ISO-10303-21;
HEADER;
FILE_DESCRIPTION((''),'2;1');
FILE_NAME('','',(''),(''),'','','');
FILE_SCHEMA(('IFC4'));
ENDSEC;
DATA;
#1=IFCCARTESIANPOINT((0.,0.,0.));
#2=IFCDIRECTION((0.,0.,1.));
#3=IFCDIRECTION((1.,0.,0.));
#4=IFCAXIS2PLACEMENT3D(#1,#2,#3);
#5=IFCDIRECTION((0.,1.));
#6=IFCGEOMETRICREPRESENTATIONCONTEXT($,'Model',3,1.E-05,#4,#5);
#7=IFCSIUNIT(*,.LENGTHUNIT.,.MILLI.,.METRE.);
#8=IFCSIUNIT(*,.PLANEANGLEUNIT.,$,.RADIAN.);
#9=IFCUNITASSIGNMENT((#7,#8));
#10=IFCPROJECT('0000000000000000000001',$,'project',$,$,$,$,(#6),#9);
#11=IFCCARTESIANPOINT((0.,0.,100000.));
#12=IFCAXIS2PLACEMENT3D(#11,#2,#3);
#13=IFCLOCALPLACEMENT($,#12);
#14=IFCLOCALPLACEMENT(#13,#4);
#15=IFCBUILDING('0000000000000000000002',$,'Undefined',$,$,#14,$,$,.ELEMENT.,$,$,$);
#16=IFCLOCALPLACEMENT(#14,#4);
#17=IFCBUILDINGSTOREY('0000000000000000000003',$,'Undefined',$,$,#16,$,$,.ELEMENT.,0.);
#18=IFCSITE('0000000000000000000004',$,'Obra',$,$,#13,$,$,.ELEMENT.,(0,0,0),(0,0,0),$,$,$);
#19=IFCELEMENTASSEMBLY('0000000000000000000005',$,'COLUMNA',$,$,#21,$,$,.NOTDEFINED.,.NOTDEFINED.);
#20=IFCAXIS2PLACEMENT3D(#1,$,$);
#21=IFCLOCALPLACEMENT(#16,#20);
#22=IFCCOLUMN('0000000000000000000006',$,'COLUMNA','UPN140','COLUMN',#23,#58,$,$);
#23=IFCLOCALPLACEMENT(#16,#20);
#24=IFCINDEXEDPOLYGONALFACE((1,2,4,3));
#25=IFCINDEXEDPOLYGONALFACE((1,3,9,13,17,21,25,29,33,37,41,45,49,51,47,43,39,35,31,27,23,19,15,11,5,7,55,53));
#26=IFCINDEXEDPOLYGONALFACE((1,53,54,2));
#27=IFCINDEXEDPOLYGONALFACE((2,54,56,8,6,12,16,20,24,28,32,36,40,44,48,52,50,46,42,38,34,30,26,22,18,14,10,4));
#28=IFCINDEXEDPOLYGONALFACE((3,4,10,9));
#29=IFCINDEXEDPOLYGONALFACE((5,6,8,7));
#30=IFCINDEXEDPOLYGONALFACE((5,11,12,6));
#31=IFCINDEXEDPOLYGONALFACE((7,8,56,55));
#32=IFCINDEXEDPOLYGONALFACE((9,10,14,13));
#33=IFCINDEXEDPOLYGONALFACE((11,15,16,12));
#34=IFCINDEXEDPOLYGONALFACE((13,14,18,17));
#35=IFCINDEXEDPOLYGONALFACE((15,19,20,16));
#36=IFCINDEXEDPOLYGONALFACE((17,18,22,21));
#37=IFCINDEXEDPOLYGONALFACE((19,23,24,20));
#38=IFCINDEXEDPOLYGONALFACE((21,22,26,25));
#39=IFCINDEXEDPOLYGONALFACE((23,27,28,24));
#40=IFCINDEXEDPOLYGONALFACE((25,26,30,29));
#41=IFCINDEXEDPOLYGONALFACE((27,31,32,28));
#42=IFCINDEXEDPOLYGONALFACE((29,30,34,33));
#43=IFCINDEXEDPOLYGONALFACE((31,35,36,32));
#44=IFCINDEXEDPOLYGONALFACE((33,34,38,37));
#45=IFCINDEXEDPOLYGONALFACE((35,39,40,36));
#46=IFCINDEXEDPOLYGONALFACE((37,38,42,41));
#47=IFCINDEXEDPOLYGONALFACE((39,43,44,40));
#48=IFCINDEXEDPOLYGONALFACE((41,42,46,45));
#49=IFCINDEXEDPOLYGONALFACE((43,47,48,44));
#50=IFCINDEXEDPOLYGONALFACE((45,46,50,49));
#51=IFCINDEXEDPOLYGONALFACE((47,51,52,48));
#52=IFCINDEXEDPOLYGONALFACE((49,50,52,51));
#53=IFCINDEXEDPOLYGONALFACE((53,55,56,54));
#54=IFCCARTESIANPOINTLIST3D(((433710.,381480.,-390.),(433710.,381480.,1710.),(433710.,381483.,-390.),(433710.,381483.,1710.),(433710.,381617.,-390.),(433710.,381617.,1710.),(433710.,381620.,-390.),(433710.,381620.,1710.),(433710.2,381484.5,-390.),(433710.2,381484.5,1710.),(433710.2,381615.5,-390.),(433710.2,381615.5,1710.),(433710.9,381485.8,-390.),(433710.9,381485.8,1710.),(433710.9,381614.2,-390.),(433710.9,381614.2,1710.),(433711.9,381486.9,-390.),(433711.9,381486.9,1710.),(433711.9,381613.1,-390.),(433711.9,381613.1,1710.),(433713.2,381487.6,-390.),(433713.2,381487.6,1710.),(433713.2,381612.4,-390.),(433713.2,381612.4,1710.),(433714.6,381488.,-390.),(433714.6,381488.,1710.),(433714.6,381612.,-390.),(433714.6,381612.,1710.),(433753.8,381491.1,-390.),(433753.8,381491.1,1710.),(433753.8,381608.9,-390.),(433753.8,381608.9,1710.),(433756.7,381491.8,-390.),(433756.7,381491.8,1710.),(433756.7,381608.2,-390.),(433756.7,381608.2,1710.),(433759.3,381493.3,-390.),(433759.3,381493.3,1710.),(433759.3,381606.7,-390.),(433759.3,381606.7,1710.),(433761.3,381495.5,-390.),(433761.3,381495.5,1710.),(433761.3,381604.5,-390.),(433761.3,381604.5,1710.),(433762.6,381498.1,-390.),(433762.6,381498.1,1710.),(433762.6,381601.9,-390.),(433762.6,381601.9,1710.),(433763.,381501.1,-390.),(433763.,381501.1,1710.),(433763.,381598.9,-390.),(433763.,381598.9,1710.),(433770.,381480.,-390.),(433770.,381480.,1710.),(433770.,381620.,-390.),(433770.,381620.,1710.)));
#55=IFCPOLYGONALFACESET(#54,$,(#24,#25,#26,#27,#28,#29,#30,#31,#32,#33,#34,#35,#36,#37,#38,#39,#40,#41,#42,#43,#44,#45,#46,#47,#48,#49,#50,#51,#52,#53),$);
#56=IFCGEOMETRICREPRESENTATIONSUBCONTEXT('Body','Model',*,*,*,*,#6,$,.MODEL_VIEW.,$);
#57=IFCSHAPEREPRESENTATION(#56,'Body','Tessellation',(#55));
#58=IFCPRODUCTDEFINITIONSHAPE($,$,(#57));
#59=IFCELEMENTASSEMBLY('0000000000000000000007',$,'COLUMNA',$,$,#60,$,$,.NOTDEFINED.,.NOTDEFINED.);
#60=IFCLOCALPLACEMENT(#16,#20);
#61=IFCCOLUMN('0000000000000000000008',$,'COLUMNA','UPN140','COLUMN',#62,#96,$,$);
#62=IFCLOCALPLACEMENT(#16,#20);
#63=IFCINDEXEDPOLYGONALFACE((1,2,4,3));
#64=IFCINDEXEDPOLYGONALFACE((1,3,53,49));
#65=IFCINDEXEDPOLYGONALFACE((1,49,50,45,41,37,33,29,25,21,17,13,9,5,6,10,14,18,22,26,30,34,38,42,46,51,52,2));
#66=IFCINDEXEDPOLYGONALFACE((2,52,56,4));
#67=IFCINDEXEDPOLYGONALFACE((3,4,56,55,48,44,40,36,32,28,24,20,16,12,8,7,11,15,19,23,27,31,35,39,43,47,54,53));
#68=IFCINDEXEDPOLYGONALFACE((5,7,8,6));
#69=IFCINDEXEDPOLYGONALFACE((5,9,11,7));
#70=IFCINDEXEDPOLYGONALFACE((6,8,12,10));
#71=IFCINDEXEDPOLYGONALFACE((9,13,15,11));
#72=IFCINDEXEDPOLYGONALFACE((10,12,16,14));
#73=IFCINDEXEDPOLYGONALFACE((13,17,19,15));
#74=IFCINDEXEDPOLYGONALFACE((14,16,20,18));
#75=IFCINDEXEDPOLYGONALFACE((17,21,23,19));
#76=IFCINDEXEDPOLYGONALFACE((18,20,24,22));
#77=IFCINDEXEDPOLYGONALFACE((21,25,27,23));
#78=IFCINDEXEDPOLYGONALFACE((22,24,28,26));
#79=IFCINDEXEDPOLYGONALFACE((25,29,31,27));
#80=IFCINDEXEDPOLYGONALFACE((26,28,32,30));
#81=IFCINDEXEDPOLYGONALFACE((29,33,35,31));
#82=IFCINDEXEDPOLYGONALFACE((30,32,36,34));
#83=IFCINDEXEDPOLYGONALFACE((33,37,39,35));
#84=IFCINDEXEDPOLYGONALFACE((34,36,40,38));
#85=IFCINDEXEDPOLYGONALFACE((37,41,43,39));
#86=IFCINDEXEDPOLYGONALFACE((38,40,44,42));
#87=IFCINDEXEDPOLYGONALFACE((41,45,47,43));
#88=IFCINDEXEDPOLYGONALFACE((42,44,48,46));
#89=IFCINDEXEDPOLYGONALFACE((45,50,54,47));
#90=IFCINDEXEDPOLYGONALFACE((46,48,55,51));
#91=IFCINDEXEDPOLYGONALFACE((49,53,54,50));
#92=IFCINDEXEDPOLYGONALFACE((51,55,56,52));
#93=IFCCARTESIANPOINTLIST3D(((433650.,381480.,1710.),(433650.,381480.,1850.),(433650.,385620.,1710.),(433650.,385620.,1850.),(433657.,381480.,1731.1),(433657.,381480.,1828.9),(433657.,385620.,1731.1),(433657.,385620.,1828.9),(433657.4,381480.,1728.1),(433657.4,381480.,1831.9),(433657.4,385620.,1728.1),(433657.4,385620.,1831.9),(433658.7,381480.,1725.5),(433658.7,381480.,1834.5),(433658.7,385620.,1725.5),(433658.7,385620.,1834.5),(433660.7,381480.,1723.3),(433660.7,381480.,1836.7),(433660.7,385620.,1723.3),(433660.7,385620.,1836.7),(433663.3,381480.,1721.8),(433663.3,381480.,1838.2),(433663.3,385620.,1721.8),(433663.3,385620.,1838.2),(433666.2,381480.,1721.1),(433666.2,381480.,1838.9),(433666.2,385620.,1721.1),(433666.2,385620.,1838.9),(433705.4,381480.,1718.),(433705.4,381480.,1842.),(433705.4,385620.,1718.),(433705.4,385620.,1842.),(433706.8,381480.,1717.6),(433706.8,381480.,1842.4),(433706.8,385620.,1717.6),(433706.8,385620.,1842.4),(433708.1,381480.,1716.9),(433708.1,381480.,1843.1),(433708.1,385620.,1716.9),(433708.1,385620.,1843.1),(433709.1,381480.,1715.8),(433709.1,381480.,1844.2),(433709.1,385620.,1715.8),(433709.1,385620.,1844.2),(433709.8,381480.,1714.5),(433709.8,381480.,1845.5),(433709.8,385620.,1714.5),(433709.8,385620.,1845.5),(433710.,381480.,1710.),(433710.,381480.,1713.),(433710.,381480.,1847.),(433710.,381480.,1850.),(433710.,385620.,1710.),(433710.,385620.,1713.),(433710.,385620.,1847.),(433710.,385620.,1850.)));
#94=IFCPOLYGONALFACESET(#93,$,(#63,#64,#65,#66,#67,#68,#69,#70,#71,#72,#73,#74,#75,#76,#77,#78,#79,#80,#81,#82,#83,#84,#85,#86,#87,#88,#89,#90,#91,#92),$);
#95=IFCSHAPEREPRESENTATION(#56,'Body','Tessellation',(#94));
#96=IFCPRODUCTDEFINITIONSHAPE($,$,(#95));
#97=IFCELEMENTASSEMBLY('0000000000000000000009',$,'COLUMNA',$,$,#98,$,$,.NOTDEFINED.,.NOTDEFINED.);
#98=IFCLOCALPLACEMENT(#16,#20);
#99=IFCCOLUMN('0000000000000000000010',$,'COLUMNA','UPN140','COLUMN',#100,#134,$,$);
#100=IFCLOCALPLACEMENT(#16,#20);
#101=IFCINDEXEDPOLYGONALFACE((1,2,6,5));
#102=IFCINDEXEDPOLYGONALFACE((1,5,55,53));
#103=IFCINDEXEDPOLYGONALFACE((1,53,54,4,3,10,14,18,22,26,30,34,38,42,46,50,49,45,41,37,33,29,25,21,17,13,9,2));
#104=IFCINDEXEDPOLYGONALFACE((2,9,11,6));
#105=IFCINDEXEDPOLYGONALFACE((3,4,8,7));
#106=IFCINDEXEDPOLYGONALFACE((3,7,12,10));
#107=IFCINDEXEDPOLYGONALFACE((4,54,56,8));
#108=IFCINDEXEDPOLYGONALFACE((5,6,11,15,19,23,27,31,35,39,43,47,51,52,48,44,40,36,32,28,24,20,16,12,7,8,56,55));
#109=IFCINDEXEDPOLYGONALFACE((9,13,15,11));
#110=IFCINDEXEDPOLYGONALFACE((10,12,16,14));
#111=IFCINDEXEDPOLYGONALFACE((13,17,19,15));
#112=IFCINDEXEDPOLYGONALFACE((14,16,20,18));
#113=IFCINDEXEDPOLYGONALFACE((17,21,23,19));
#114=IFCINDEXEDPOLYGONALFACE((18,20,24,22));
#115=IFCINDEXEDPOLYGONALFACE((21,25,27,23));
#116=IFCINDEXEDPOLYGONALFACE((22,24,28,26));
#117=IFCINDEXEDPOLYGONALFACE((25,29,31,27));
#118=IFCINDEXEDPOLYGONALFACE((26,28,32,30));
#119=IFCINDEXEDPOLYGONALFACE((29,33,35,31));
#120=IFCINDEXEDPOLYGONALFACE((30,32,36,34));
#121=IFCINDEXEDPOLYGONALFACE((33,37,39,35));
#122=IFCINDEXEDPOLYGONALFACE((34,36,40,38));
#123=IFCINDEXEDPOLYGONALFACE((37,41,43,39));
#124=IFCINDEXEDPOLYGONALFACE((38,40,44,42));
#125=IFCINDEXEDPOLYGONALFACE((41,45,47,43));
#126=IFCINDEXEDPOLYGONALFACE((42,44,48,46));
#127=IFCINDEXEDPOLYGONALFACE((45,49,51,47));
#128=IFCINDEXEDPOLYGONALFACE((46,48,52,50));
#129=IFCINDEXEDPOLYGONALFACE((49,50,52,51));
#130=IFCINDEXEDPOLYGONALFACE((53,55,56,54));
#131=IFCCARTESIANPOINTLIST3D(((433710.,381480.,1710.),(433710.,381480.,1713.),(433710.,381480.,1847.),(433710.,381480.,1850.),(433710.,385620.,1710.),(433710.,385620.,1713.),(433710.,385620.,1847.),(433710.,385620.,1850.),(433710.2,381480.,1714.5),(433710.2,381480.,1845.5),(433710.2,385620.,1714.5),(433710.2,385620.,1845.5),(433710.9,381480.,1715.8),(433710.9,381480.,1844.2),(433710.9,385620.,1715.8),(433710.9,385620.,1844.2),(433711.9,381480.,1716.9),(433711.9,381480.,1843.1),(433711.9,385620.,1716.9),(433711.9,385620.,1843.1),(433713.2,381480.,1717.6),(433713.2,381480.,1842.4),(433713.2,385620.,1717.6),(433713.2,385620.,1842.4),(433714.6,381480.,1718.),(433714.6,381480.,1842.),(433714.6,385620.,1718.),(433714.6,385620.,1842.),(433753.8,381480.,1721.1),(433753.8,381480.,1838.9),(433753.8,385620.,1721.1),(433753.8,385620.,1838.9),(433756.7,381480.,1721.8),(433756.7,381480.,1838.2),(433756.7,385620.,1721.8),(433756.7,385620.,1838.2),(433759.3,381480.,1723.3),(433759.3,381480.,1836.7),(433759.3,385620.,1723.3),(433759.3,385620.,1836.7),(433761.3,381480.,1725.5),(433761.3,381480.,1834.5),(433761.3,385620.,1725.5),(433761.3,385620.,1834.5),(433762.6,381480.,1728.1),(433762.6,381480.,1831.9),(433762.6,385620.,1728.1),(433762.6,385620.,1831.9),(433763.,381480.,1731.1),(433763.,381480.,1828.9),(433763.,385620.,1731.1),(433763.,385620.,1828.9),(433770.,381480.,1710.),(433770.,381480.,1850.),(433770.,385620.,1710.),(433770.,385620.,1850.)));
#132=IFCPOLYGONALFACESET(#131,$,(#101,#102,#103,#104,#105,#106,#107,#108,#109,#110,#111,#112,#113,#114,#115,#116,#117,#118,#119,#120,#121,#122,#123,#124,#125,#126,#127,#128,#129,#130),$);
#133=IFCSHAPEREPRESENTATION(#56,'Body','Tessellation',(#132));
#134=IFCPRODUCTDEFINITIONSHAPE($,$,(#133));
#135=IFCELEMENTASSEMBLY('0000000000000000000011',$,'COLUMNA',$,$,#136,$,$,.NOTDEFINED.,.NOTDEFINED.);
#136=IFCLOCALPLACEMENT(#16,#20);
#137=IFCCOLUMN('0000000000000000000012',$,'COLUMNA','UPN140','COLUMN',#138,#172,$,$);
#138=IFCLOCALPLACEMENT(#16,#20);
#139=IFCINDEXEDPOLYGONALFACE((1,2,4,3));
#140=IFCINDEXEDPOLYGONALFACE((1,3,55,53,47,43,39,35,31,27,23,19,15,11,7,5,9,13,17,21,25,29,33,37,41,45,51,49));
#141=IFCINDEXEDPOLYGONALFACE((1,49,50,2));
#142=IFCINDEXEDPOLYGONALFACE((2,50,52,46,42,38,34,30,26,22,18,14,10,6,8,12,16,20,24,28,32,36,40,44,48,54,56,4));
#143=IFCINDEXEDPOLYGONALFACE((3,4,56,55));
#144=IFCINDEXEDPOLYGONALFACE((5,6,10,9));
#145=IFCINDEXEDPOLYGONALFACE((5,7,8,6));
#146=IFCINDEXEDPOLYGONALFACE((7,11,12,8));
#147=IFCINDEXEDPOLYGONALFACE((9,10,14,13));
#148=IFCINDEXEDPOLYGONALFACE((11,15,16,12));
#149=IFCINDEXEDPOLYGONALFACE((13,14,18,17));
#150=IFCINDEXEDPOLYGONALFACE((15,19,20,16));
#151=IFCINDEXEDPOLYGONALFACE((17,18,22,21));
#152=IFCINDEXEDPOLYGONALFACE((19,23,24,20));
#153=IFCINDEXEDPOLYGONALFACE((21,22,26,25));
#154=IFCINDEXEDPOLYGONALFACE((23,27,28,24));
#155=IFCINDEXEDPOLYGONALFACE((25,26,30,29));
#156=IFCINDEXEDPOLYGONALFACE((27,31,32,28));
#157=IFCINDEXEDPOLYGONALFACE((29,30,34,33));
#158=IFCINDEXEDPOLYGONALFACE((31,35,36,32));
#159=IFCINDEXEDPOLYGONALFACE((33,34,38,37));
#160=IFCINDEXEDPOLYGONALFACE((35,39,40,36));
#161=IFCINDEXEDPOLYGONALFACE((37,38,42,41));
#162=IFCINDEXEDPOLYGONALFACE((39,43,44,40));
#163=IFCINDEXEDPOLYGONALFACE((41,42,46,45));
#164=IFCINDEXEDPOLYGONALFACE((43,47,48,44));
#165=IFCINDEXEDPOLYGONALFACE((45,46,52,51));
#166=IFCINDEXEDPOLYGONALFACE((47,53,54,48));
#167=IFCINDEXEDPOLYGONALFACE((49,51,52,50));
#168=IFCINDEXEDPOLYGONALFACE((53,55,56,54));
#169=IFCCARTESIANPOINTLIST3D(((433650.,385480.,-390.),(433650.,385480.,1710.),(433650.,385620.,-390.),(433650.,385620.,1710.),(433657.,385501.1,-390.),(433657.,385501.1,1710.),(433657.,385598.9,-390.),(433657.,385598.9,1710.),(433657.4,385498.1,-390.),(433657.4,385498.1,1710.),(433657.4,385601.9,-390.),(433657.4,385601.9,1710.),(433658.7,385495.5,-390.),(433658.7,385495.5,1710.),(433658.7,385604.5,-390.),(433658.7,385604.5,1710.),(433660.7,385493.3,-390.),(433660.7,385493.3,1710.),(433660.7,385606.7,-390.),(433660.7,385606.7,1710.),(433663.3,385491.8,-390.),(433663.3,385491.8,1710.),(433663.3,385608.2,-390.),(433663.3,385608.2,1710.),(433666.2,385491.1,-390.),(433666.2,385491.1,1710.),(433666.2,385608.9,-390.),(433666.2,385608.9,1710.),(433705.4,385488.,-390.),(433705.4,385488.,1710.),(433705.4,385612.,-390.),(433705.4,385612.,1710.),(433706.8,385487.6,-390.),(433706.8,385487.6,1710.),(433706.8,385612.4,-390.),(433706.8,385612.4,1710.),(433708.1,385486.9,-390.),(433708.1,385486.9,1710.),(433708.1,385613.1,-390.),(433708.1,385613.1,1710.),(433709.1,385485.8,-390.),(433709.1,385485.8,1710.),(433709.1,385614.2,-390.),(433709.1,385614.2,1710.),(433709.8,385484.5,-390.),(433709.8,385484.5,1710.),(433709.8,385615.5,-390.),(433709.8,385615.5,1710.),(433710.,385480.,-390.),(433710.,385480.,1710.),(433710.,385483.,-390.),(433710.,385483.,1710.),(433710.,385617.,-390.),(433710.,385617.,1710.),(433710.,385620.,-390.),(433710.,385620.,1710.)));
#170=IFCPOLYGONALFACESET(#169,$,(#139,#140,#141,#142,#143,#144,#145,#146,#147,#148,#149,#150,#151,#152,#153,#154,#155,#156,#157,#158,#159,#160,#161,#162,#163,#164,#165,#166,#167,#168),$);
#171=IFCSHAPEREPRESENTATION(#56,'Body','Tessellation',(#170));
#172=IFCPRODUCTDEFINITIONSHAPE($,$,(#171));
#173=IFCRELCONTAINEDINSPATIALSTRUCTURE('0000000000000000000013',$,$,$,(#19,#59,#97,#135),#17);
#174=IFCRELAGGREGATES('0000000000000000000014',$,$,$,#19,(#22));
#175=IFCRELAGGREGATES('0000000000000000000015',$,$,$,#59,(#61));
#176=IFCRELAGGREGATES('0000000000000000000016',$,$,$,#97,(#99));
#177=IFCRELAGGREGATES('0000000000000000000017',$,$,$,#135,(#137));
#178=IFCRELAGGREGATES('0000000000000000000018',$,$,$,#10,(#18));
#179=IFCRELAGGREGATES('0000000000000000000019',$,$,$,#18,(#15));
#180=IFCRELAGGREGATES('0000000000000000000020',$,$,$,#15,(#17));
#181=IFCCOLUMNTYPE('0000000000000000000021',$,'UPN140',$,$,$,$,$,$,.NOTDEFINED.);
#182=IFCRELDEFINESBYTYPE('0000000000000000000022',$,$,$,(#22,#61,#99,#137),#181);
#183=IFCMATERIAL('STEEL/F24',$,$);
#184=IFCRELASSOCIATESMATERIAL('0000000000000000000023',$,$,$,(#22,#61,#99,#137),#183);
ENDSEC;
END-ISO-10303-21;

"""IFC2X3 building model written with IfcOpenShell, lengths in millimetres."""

from ifc_helpers import new_model, si_unit, direction, frame, origin_with_axes, origin_2d_with_axis, place, context, subcontext, project, spatial, u_section, extrude, material, type_object, element, aggregate, save


model = new_model("IFC2X3")

# Units and contexts
model_context = context("Model", 3, precision=1e-05, world=origin_with_axes(), true_north=direction((0.0, 1.0)))
body_context = subcontext(model_context, "Body", "Model", "MODEL_VIEW")
ifc_project = project(units=[si_unit("LENGTHUNIT", "METRE", prefix="MILLI"), si_unit("PLANEANGLEUNIT", "RADIAN")], contexts=[model_context])

# Site, building, storey
site_placement = place(None, frame((0.0, 0.0, 100000.0), z_axis=(0.0, 0.0, 1.0), x_axis=(1.0, 0.0, 0.0)))
site = spatial("IfcSite", under=ifc_project, at=site_placement, Name="Obra", CompositionType="ELEMENT", RefLatitude=(0, 0, 0), RefLongitude=(0, 0, 0))
building_placement = place(site_placement, origin_with_axes())
building = spatial("IfcBuilding", under=site, at=building_placement, Name="Undefined", CompositionType="ELEMENT")
storey_placement = place(building_placement, origin_with_axes())
storey = spatial("IfcBuildingStorey", under=building, at=storey_placement, Name="Undefined", CompositionType="ELEMENT", Elevation=0.0)

# Element assemblies, columns
ifc_material_1 = material(Name="STEEL/F24")
column_type_1 = type_object("IfcColumnType", Name="UPN140", PredefinedType="NOTDEFINED")
assembly_1_placement = place(storey_placement, origin_with_axes())
assembly_1 = element("IfcElementAssembly", 1, at=assembly_1_placement, inside=storey, Name="COLUMNA", AssemblyPlace="NOTDEFINED", PredefinedType="NOTDEFINED")
column_1_placement = place(assembly_1_placement, frame((433740.0, 381550.0, 1710.0), z_axis=(0.0, 0.0, -1.0), x_axis=(0.0, -1.0, 0.0)))
column_1 = element("IfcColumn", 2, at=column_1_placement, type_object=column_type_1, material=ifc_material_1, Name="COLUMNA", Description="UPN140", ObjectType="COLUMN", context=body_context, shape_type="SweptSolid", body=[
    extrude(u_section(Depth=140.0, FlangeWidth=60.0, WebThickness=7.0, FlangeThickness=10.0, FilletRadius=10.0, EdgeRadius=5.0, FlangeSlope=0.07983, at=origin_2d_with_axis()), frame((0.0, 0.0, 2100.0), z_axis=(0.0, 0.0, -1.0), x_axis=(0.0, 1.0, 0.0)), (0.0, 0.0, 1.0), 2100.0),
])
aggregate(assembly_1, [column_1])
assembly_2_placement = place(storey_placement, origin_with_axes())
assembly_2 = element("IfcElementAssembly", 3, at=assembly_2_placement, inside=storey, Name="COLUMNA", AssemblyPlace="NOTDEFINED", PredefinedType="NOTDEFINED")
column_2_placement = place(assembly_2_placement, frame((433680.0, 385620.0, 1780.0), z_axis=(0.0, -1.0, 0.0), x_axis=(0.0, 0.0, -1.0)))
column_2 = element("IfcColumn", 4, at=column_2_placement, type_object=column_type_1, material=ifc_material_1, Name="COLUMNA", Description="UPN140", ObjectType="COLUMN", context=body_context, shape_type="SweptSolid", body=[
    extrude(u_section(Depth=140.0, FlangeWidth=60.0, WebThickness=7.0, FlangeThickness=10.0, FilletRadius=10.0, EdgeRadius=5.0, FlangeSlope=0.07983, at=origin_2d_with_axis()), frame((0.0, 0.0, 4140.0), z_axis=(0.0, 0.0, -1.0), x_axis=(0.0, 1.0, 0.0)), (0.0, 0.0, 1.0), 4140.0),
])
aggregate(assembly_2, [column_2])
assembly_3_placement = place(storey_placement, origin_with_axes())
assembly_3 = element("IfcElementAssembly", 5, at=assembly_3_placement, inside=storey, Name="COLUMNA", AssemblyPlace="NOTDEFINED", PredefinedType="NOTDEFINED")
column_3_placement = place(assembly_3_placement, frame((433740.0, 385620.0, 1780.0), z_axis=(0.0, -1.0, 0.0), x_axis=(0.0, 0.0, 1.0)))
column_3 = element("IfcColumn", 6, at=column_3_placement, type_object=column_type_1, material=ifc_material_1, Name="COLUMNA", Description="UPN140", ObjectType="COLUMN", context=body_context, shape_type="SweptSolid", body=[
    extrude(u_section(Depth=140.0, FlangeWidth=60.0, WebThickness=7.0, FlangeThickness=10.0, FilletRadius=10.0, EdgeRadius=5.0, FlangeSlope=0.07983, at=origin_2d_with_axis()), frame((0.0, 0.0, 4140.0), z_axis=(0.0, 0.0, -1.0), x_axis=(0.0, 1.0, 0.0)), (0.0, 0.0, 1.0), 4140.0),
])
aggregate(assembly_3, [column_3])
assembly_4_placement = place(storey_placement, origin_with_axes())
assembly_4 = element("IfcElementAssembly", 7, at=assembly_4_placement, inside=storey, Name="COLUMNA", AssemblyPlace="NOTDEFINED", PredefinedType="NOTDEFINED")
column_4_placement = place(assembly_4_placement, frame((433680.0, 385550.0, -390.0), z_axis=(0.0, 0.0, 1.0), x_axis=(0.0, -1.0, 0.0)))
column_4 = element("IfcColumn", 8, at=column_4_placement, type_object=column_type_1, material=ifc_material_1, Name="COLUMNA", Description="UPN140", ObjectType="COLUMN", context=body_context, shape_type="SweptSolid", body=[
    extrude(u_section(Depth=140.0, FlangeWidth=60.0, WebThickness=7.0, FlangeThickness=10.0, FilletRadius=10.0, EdgeRadius=5.0, FlangeSlope=0.07983, at=origin_2d_with_axis()), frame((0.0, 0.0, 2100.0), z_axis=(0.0, 0.0, -1.0), x_axis=(0.0, 1.0, 0.0)), (0.0, 0.0, 1.0), 2100.0),
])
aggregate(assembly_4, [column_4])

save(model, "model.ifc")
